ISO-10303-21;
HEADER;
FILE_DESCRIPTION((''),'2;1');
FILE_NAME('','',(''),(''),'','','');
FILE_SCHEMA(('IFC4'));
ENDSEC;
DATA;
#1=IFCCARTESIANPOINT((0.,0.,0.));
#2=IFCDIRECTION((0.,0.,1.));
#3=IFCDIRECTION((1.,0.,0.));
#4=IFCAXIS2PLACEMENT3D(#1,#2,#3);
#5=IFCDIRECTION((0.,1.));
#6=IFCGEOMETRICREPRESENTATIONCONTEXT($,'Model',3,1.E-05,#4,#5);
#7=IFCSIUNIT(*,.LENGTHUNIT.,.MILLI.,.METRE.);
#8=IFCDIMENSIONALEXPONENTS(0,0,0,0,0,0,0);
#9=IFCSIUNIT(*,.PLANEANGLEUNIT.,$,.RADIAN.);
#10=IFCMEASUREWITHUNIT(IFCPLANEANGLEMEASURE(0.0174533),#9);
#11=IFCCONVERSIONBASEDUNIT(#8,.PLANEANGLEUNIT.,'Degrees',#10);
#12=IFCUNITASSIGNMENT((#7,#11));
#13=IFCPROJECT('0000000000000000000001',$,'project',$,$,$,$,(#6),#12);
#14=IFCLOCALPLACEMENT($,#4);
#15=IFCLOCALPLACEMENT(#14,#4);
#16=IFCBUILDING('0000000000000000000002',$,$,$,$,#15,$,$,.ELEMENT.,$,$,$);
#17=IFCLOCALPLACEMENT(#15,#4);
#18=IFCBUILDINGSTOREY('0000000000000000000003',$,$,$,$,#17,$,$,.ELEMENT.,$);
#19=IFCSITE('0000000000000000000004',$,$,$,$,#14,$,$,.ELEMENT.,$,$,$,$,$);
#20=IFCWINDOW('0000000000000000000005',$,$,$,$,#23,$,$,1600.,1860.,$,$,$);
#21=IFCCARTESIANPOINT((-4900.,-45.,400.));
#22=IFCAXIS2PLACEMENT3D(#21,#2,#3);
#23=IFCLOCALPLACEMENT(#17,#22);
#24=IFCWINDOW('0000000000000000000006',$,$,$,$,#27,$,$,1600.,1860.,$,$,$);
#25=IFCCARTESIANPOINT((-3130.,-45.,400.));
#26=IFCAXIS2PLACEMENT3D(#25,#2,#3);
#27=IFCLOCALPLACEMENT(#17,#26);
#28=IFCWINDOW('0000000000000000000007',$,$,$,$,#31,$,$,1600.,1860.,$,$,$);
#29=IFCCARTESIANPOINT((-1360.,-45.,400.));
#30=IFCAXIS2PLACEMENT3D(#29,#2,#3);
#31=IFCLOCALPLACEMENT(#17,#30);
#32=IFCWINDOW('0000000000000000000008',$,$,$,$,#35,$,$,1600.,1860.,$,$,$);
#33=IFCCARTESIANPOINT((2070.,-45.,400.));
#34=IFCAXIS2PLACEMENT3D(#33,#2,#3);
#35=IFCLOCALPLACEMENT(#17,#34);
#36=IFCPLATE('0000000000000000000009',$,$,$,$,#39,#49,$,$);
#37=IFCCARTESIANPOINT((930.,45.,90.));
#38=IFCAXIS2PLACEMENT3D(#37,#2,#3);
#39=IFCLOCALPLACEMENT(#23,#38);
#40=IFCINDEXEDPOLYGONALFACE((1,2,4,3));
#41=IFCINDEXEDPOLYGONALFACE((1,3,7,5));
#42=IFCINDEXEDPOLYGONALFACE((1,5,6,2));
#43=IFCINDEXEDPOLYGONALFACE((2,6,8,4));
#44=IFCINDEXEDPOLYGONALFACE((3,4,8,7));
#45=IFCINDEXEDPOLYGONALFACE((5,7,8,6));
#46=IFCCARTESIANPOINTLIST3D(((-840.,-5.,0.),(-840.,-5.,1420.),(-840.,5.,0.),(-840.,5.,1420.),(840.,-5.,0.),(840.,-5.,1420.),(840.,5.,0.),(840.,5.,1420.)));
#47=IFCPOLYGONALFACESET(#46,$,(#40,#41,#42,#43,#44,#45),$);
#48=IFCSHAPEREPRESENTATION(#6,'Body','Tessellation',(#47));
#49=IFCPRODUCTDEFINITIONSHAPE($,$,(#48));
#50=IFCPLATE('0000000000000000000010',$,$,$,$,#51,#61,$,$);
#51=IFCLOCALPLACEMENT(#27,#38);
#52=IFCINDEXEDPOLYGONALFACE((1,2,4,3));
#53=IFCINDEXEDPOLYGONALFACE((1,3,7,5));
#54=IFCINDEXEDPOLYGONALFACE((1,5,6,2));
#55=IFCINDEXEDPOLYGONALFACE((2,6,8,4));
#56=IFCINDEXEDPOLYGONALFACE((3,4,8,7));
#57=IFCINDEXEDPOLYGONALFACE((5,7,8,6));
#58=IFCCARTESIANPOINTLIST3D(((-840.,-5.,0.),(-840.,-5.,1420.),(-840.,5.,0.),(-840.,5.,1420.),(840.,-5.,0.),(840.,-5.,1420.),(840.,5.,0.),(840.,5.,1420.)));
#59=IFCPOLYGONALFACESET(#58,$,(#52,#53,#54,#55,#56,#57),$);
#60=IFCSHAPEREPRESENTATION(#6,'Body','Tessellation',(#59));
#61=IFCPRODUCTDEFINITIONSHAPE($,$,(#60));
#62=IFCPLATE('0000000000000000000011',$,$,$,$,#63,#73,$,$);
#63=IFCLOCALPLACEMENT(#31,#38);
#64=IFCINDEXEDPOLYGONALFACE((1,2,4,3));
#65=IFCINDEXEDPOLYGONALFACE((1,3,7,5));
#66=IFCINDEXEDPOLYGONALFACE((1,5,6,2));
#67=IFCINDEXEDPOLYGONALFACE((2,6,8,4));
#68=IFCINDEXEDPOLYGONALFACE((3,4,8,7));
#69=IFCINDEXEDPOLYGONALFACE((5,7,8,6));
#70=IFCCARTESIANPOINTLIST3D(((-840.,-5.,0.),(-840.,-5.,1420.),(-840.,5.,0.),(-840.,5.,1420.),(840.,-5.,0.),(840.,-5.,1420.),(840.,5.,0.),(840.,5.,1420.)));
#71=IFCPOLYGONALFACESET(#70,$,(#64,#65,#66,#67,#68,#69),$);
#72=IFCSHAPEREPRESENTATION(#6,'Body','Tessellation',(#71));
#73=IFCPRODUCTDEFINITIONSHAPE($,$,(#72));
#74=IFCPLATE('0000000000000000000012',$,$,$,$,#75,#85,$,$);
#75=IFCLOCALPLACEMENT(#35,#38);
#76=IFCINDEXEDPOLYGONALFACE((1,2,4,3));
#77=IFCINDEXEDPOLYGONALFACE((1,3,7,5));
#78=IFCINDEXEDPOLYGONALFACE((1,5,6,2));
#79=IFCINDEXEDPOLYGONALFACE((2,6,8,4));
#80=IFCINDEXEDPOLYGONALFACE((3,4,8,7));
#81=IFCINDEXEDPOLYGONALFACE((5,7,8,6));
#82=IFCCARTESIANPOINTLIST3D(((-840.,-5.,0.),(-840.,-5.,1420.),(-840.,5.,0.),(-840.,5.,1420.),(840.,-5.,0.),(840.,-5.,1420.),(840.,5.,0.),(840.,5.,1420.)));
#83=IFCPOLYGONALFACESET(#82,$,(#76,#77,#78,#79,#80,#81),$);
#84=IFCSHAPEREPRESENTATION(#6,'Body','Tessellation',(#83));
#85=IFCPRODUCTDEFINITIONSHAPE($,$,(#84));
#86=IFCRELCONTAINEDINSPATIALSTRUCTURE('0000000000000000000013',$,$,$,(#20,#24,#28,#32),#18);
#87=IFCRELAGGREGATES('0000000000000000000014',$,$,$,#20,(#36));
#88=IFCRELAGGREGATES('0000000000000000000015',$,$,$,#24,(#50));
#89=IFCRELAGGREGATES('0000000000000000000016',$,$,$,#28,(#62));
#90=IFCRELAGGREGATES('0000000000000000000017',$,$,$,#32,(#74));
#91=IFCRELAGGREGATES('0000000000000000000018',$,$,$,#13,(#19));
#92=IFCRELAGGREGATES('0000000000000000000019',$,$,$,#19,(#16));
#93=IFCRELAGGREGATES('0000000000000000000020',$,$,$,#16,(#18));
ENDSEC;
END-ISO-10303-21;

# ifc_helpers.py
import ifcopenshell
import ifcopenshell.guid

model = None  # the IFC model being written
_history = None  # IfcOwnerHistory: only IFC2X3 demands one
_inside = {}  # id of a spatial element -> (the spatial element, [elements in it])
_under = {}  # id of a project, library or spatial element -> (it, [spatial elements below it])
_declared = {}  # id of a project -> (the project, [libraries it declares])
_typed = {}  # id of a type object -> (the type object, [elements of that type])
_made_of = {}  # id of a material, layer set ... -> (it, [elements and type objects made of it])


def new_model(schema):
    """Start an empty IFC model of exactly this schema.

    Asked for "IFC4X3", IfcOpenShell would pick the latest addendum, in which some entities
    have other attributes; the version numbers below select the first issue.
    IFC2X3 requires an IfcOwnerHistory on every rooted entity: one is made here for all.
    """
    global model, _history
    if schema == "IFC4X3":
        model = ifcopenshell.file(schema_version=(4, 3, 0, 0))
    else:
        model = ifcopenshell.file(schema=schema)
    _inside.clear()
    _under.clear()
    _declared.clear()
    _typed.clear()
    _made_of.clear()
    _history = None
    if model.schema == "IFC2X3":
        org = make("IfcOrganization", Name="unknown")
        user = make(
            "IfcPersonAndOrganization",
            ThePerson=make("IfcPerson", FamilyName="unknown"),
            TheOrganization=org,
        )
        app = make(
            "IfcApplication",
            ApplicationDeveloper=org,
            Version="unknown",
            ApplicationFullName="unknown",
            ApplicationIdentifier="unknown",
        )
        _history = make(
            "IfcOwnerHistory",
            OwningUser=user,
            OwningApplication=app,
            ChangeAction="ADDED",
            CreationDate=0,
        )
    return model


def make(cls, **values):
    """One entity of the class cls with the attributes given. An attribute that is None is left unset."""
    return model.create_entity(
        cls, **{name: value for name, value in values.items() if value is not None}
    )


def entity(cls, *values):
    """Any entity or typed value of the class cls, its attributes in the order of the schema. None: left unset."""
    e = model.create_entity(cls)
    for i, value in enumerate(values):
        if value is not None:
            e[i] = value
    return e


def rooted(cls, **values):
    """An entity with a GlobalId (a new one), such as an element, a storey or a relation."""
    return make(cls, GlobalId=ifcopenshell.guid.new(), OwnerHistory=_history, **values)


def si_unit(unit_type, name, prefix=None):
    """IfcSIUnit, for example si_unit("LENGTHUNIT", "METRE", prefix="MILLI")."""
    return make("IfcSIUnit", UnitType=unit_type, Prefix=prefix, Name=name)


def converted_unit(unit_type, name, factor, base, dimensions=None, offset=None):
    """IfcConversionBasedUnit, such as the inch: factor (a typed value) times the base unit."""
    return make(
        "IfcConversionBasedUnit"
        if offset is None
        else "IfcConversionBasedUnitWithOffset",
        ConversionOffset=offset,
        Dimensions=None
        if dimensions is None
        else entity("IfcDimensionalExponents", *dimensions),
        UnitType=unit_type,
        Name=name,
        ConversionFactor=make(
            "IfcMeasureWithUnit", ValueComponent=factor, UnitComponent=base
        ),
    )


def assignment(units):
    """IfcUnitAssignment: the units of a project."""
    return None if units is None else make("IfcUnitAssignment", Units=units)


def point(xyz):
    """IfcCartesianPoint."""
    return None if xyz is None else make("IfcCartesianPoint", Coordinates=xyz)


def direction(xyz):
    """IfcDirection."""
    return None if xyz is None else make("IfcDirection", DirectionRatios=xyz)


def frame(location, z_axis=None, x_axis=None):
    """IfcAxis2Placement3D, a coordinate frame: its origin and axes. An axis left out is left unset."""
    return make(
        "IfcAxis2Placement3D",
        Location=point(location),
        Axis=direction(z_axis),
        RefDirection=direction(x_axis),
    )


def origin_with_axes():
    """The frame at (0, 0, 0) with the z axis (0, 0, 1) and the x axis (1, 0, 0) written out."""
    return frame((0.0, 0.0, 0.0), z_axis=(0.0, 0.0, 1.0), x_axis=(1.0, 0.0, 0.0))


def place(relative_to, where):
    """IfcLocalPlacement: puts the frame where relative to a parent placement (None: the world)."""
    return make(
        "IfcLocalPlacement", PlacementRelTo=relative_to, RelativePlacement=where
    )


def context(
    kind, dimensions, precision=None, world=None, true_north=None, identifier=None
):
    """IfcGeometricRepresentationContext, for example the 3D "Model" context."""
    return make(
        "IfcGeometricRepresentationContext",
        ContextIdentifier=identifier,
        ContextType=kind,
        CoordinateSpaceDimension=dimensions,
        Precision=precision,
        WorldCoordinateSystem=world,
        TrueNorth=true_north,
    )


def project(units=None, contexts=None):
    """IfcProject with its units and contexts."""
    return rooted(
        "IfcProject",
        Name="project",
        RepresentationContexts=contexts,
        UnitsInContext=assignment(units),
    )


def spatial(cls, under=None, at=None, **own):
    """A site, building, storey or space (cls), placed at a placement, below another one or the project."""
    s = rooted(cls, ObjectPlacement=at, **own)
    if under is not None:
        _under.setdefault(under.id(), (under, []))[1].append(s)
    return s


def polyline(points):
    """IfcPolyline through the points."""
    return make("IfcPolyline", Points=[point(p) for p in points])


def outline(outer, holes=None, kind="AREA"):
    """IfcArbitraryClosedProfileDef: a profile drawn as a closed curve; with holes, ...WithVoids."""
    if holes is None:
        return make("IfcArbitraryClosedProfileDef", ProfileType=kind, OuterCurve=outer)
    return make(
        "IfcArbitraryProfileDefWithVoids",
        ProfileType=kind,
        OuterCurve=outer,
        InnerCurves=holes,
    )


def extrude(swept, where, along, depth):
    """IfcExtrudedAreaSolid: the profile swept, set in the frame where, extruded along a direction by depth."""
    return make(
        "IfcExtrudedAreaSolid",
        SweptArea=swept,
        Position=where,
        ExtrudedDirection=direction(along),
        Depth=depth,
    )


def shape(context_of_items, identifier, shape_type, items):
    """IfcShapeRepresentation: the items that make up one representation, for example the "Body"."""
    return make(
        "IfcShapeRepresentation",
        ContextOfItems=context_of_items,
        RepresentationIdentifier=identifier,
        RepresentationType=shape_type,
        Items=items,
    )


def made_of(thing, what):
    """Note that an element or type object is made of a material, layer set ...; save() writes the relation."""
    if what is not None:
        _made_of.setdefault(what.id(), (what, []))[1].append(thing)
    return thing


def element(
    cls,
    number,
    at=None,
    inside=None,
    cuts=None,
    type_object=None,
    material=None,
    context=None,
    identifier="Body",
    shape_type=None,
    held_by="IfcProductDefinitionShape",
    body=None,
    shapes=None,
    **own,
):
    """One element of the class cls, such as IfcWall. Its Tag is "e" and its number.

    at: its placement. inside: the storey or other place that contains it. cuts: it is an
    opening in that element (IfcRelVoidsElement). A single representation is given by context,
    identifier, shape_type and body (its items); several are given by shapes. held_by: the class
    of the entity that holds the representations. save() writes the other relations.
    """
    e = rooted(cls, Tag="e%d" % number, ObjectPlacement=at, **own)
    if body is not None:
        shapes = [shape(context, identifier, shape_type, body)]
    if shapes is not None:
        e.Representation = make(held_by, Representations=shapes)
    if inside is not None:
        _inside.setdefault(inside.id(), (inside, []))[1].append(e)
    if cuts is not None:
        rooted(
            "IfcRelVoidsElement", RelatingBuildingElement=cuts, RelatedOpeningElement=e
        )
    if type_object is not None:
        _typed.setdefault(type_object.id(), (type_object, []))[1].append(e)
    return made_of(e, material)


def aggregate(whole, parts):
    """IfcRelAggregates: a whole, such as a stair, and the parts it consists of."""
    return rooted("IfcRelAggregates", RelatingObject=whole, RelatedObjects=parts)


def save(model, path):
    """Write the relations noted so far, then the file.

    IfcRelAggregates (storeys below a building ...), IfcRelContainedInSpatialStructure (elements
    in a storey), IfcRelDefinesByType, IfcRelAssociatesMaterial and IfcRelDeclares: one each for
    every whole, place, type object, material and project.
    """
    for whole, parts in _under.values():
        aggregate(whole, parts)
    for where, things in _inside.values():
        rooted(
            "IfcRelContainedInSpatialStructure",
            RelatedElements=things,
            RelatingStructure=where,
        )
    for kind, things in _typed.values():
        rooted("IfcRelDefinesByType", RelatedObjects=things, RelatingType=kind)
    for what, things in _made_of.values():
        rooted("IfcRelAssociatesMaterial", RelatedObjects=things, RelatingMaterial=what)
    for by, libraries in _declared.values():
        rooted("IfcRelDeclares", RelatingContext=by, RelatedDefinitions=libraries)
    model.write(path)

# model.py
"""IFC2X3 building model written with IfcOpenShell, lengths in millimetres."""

from ifc_helpers import new_model, entity, si_unit, converted_unit, direction, frame, origin_with_axes, place, context, project, spatial, polyline, outline, extrude, element, aggregate, save


model = new_model("IFC2X3")

# Units and contexts
model_context = context("Model", 3, precision=1e-05, world=origin_with_axes(), true_north=direction((0.0, 1.0)))
ifc_project = project(units=[si_unit("LENGTHUNIT", "METRE", prefix="MILLI"), converted_unit("PLANEANGLEUNIT", "Degrees", entity("IfcPlaneAngleMeasure", 0.0174533), si_unit("PLANEANGLEUNIT", "RADIAN"), dimensions=[0, 0, 0, 0, 0, 0, 0])], contexts=[model_context])

# Site, building, storey
site_placement = place(None, origin_with_axes())
site = spatial("IfcSite", under=ifc_project, at=site_placement, CompositionType="ELEMENT")
building_placement = place(site_placement, origin_with_axes())
building = spatial("IfcBuilding", under=site, at=building_placement, CompositionType="ELEMENT")
storey_placement = place(building_placement, origin_with_axes())
storey = spatial("IfcBuildingStorey", under=building, at=storey_placement, CompositionType="ELEMENT")

# Windows
window_1_placement = place(storey_placement, frame((-4900.0, -45.0, 400.0), z_axis=(0.0, 0.0, 1.0), x_axis=(1.0, 0.0, 0.0)))
window_1 = element("IfcWindow", 1, at=window_1_placement, inside=storey, OverallHeight=1600.0, OverallWidth=1860.0)
window_2_placement = place(storey_placement, frame((-3130.0, -45.0, 400.0), z_axis=(0.0, 0.0, 1.0), x_axis=(1.0, 0.0, 0.0)))
window_2 = element("IfcWindow", 2, at=window_2_placement, inside=storey, OverallHeight=1600.0, OverallWidth=1860.0)
window_3_placement = place(storey_placement, frame((-1360.0, -45.0, 400.0), z_axis=(0.0, 0.0, 1.0), x_axis=(1.0, 0.0, 0.0)))
window_3 = element("IfcWindow", 3, at=window_3_placement, inside=storey, OverallHeight=1600.0, OverallWidth=1860.0)
window_4_placement = place(storey_placement, frame((2070.0, -45.0, 400.0), z_axis=(0.0, 0.0, 1.0), x_axis=(1.0, 0.0, 0.0)))
window_4 = element("IfcWindow", 4, at=window_4_placement, inside=storey, OverallHeight=1600.0, OverallWidth=1860.0)

# Plates
plate_1_placement = place(window_1_placement, frame((930.0, 45.0, 90.0), z_axis=(0.0, 0.0, 1.0), x_axis=(1.0, 0.0, 0.0)))
plate_1 = element("IfcPlate", 5, at=plate_1_placement, context=model_context, shape_type="SweptSolid", body=[
    extrude(outline(polyline([(-840.0, -5.0), (840.0, -5.0), (840.0, 5.0), (-840.0, 5.0), (-840.0, -5.0), (-840.0, -5.0)])), origin_with_axes(), (0.0, 0.0, 1.0), 1420.0),
])
aggregate(window_1, [plate_1])
plate_2_placement = place(window_2_placement, frame((930.0, 45.0, 90.0), z_axis=(0.0, 0.0, 1.0), x_axis=(1.0, 0.0, 0.0)))
plate_2 = element("IfcPlate", 6, at=plate_2_placement, context=model_context, shape_type="SweptSolid", body=[
    extrude(outline(polyline([(-840.0, -5.0), (840.0, -5.0), (840.0, 5.0), (-840.0, 5.0), (-840.0, -5.0), (-840.0, -5.0)])), origin_with_axes(), (0.0, 0.0, 1.0), 1420.0),
])
aggregate(window_2, [plate_2])
plate_3_placement = place(window_3_placement, frame((930.0, 45.0, 90.0), z_axis=(0.0, 0.0, 1.0), x_axis=(1.0, 0.0, 0.0)))
plate_3 = element("IfcPlate", 7, at=plate_3_placement, context=model_context, shape_type="SweptSolid", body=[
    extrude(outline(polyline([(-840.0, -5.0), (840.0, -5.0), (840.0, 5.0), (-840.0, 5.0), (-840.0, -5.0), (-840.0, -5.0)])), origin_with_axes(), (0.0, 0.0, 1.0), 1420.0),
])
aggregate(window_3, [plate_3])
plate_4_placement = place(window_4_placement, frame((930.0, 45.0, 90.0), z_axis=(0.0, 0.0, 1.0), x_axis=(1.0, 0.0, 0.0)))
plate_4 = element("IfcPlate", 8, at=plate_4_placement, context=model_context, shape_type="SweptSolid", body=[
    extrude(outline(polyline([(-840.0, -5.0), (840.0, -5.0), (840.0, 5.0), (-840.0, 5.0), (-840.0, -5.0), (-840.0, -5.0)])), origin_with_axes(), (0.0, 0.0, 1.0), 1420.0),
])
aggregate(window_4, [plate_4])

save(model, "model.ifc")
